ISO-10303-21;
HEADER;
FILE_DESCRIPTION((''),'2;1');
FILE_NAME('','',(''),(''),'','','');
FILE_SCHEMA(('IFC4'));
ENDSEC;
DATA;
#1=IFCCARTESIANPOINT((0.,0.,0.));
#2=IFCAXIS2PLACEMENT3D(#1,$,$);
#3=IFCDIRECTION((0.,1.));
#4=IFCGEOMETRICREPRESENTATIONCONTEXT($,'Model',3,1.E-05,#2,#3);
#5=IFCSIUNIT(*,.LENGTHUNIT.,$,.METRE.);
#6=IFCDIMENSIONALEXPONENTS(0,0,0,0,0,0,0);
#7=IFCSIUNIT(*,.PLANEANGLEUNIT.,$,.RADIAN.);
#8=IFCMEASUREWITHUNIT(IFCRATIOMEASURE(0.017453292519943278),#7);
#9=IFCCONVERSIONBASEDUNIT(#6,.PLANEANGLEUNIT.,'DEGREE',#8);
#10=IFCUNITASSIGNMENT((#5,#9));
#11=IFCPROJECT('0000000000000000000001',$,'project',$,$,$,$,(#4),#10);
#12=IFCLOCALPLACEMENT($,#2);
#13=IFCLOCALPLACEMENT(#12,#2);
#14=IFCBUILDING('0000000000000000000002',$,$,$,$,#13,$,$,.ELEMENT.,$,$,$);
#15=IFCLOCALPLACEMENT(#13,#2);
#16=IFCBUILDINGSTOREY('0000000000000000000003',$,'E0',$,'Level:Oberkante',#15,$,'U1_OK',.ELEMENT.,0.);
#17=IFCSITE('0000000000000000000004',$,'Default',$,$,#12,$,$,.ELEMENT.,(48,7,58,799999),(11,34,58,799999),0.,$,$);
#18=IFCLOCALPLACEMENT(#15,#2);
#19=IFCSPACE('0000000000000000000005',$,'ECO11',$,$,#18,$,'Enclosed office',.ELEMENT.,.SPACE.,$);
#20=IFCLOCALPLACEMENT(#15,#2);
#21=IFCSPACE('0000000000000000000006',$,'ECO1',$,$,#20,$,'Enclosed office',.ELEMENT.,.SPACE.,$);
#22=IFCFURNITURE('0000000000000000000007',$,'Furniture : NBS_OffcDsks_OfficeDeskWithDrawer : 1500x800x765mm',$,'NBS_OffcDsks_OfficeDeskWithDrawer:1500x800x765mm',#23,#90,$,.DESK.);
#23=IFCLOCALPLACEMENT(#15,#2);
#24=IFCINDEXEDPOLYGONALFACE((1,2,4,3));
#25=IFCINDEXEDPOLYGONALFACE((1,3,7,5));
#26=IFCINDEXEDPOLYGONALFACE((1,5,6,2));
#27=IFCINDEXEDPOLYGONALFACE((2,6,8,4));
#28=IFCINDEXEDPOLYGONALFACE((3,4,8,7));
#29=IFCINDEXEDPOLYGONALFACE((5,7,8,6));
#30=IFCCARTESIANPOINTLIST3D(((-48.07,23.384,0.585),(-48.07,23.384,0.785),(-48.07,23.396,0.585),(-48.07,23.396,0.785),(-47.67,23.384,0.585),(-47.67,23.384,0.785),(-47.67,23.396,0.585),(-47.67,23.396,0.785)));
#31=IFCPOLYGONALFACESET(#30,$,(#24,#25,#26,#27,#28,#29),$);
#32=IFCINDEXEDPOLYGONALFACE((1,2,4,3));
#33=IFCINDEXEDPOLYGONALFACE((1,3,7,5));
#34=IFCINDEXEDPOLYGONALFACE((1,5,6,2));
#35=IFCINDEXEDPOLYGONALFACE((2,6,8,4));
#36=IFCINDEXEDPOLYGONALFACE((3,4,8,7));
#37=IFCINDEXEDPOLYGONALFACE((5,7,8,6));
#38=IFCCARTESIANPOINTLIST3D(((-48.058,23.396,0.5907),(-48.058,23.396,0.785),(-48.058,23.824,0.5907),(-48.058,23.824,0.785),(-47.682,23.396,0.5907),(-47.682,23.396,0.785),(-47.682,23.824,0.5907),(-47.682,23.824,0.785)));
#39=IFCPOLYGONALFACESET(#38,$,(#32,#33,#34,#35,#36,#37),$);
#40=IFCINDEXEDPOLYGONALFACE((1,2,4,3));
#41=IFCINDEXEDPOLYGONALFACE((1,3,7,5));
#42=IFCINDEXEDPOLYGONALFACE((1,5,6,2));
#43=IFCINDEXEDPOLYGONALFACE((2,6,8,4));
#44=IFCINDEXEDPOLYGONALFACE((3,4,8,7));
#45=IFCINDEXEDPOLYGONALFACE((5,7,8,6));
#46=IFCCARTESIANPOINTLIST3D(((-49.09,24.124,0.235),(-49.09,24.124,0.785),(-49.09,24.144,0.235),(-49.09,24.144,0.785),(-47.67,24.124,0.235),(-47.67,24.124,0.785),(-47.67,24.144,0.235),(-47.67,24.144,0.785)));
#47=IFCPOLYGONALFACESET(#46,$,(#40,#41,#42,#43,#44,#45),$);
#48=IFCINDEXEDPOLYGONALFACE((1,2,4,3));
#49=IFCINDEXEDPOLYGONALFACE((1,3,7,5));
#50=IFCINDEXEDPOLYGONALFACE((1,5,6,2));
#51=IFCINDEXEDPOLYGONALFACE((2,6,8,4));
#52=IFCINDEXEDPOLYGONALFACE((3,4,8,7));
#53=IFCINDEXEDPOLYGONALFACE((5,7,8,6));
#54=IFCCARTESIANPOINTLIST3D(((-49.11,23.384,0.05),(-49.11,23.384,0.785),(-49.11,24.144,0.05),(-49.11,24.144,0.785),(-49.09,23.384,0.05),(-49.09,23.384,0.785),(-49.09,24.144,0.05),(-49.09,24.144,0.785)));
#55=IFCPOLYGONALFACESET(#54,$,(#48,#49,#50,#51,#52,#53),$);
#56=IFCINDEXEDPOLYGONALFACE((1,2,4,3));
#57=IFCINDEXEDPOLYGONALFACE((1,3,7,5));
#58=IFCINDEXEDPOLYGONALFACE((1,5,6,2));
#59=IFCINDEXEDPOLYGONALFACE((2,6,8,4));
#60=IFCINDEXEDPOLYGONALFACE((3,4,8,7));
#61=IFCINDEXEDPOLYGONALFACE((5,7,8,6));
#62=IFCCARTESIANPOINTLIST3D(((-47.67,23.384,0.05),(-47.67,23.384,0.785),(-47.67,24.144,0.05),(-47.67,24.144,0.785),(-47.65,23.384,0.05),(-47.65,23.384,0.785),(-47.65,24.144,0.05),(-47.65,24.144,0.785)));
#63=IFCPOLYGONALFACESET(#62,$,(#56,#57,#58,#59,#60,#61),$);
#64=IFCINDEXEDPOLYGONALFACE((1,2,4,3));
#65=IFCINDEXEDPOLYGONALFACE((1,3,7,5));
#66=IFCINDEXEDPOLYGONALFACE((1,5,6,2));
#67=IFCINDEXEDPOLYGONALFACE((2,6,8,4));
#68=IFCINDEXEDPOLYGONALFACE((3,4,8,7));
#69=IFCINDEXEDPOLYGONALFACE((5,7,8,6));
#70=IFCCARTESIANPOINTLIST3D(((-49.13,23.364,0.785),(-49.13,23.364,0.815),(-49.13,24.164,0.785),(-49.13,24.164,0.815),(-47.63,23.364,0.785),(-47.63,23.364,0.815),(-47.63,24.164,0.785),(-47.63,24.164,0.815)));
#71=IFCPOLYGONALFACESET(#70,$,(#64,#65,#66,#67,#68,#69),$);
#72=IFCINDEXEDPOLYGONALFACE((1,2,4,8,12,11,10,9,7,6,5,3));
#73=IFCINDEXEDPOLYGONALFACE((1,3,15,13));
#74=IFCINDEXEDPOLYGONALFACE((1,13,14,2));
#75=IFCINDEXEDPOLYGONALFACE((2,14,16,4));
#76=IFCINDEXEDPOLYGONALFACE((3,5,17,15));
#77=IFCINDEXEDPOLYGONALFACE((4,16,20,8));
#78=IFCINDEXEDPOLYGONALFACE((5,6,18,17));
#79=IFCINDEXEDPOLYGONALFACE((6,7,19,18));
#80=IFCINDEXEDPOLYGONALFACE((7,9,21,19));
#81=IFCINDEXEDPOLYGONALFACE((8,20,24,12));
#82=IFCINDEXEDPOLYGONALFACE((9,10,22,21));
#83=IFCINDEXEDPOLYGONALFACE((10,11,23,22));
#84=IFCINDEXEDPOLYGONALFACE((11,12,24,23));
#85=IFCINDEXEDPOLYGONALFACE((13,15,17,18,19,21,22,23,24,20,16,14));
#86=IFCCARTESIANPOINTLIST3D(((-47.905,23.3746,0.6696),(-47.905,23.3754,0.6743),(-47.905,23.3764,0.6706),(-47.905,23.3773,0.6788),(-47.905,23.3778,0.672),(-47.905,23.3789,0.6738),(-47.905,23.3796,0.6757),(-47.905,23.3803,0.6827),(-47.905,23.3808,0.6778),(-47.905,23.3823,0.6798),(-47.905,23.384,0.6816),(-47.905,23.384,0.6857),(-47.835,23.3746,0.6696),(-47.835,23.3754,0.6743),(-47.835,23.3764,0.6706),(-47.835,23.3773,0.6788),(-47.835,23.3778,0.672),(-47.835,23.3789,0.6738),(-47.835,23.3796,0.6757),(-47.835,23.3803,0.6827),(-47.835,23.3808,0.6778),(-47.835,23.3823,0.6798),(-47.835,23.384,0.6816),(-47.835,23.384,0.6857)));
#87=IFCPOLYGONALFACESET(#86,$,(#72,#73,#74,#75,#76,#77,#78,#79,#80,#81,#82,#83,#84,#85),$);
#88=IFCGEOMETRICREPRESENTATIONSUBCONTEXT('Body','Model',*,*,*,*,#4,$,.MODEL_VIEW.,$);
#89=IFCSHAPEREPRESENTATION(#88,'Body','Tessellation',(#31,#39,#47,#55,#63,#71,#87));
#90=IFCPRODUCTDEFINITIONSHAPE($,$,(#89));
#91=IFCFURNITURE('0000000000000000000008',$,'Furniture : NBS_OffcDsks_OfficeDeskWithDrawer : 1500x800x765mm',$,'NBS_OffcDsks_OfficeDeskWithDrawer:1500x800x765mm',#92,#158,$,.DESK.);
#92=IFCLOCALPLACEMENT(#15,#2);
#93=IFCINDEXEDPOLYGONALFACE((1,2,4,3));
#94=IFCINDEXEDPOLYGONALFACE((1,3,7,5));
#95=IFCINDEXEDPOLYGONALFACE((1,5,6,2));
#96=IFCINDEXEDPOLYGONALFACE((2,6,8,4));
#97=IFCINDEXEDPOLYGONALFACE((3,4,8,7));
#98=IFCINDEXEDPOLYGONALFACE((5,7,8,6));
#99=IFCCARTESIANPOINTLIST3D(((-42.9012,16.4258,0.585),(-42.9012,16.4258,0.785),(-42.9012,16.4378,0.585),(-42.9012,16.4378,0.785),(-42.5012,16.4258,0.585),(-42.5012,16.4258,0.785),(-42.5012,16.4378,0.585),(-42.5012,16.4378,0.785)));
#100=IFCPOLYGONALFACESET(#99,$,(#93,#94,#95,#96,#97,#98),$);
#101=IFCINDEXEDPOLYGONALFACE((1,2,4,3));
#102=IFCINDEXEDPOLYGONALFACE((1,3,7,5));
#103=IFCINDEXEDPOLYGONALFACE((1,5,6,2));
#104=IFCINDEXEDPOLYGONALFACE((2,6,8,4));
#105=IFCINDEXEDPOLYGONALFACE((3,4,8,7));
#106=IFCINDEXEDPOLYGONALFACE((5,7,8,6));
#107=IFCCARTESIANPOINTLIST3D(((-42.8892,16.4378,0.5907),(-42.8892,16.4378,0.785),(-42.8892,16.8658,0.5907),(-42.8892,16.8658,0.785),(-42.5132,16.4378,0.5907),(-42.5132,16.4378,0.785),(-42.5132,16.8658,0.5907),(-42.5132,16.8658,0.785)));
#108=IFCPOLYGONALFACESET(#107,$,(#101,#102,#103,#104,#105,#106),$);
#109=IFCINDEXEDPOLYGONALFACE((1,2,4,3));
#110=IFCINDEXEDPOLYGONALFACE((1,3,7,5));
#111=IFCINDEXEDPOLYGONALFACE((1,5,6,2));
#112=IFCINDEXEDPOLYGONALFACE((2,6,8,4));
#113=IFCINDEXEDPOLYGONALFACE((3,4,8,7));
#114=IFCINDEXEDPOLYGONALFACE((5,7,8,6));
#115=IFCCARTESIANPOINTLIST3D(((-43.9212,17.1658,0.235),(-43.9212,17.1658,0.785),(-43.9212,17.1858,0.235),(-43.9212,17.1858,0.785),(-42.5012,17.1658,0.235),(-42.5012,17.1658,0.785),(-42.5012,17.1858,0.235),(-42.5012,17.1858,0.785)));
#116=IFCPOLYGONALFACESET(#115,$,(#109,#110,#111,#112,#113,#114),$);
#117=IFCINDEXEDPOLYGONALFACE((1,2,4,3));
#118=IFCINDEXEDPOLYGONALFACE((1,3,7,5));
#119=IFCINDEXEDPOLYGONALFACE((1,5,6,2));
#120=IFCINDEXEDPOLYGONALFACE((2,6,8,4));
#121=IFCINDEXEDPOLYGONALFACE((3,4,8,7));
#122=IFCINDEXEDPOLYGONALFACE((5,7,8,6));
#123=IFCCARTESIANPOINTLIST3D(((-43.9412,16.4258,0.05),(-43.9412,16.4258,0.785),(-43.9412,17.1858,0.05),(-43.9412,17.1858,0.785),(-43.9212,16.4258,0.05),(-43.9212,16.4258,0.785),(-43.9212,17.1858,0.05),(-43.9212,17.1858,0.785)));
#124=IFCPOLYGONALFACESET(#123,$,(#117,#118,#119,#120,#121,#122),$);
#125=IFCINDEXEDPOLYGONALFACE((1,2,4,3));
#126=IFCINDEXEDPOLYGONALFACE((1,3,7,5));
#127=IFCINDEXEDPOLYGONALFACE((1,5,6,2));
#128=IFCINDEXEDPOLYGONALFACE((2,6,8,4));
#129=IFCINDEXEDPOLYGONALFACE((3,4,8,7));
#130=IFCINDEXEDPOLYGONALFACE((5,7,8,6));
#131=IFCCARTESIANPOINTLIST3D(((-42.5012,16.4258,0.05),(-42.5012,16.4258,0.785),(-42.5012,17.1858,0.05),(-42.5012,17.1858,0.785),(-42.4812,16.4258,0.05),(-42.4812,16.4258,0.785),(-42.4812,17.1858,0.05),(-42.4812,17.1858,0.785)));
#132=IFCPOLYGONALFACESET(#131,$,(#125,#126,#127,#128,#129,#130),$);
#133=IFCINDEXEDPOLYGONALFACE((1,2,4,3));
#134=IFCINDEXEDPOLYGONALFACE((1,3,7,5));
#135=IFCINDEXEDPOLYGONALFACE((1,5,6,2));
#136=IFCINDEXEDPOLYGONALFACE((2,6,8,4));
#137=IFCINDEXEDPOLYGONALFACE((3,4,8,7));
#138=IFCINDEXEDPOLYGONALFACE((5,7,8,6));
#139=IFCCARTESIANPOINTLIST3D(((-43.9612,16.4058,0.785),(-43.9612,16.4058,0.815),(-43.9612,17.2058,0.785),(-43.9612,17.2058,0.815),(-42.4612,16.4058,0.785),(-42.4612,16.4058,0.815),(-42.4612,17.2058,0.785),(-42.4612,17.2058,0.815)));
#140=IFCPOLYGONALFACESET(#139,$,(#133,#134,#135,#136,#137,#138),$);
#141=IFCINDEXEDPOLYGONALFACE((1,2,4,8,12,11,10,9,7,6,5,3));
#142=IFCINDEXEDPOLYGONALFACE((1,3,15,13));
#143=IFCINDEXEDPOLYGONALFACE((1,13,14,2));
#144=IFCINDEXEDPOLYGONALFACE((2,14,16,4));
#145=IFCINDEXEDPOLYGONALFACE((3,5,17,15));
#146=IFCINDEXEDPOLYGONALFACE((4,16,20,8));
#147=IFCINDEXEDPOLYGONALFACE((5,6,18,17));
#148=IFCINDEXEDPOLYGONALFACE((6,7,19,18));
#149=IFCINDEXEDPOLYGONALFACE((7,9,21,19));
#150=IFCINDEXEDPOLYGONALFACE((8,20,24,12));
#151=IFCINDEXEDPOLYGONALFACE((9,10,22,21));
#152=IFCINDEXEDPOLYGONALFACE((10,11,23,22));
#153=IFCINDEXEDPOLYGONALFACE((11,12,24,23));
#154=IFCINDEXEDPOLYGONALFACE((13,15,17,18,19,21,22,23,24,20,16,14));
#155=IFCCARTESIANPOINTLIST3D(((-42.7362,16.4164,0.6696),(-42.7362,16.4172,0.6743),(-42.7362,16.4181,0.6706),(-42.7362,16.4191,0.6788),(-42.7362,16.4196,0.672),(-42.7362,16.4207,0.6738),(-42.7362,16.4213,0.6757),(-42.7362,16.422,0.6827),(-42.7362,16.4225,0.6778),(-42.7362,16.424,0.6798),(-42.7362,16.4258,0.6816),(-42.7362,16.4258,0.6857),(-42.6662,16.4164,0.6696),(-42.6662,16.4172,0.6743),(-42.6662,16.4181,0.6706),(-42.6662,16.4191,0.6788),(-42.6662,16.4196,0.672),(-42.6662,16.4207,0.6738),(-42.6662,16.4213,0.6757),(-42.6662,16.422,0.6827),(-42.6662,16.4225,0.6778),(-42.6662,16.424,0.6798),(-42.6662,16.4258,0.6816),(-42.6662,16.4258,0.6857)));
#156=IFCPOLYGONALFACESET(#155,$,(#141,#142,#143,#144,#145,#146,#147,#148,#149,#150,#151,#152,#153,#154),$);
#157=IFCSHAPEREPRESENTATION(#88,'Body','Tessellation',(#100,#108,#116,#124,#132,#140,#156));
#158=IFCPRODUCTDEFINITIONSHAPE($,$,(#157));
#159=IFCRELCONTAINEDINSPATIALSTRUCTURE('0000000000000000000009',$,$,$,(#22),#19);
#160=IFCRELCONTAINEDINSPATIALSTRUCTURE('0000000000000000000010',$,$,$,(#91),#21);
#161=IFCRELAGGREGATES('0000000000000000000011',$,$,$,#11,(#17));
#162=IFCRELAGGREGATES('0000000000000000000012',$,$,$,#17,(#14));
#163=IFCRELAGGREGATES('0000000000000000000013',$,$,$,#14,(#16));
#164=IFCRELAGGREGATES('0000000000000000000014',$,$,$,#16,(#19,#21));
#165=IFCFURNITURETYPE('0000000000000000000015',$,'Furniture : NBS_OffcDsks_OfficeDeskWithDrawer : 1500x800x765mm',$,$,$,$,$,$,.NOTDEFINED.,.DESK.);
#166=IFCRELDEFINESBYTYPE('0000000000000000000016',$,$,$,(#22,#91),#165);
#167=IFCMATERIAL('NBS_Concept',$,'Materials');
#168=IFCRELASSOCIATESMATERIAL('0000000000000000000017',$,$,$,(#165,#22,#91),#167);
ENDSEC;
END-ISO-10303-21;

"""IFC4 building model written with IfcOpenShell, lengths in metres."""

from ifc_helpers import new_model, entity, si_unit, converted_unit, direction, frame, origin, place, context, subcontext, project, spatial, line, arc, indexed_curve, outline, extrude, source, transform, mapped, material, type_object, type_shapes, element, save


model = new_model("IFC4")

# Units and contexts
model_context = context("Model", 3, precision=1e-05, world=origin(), true_north=direction((0.0, 1.0)))
body_context = subcontext(model_context, "Body", "Model", "MODEL_VIEW")
ifc_project = project(units=[si_unit("LENGTHUNIT", "METRE"), converted_unit("PLANEANGLEUNIT", "DEGREE", entity("IfcRatioMeasure", 0.017453292519943278), si_unit("PLANEANGLEUNIT", "RADIAN"), dimensions=[0, 0, 0, 0, 0, 0, 0])], contexts=[model_context])

# Site, building, storey
site_placement = place(None, origin())
site = spatial("IfcSite", under=ifc_project, at=site_placement, Name="Default", CompositionType="ELEMENT", RefLatitude=(48, 7, 58, 799999), RefLongitude=(11, 34, 58, 799999), RefElevation=0.0)
building_placement = place(site_placement, origin())
building = spatial("IfcBuilding", under=site, at=building_placement, CompositionType="ELEMENT")
storey_placement = place(building_placement, origin())
storey = spatial("IfcBuildingStorey", under=building, at=storey_placement, Name="E0", ObjectType="Level:Oberkante", LongName="U1_OK", CompositionType="ELEMENT", Elevation=0.0)

# Shared definitions
ifc_material_1 = material(Name="NBS_Concept", Category="Materials")
furniture_type = type_object("IfcFurnitureType", Name="Furniture : NBS_OffcDsks_OfficeDeskWithDrawer : 1500x800x765mm", AssemblyPlace="NOTDEFINED", PredefinedType="DESK", material=ifc_material_1)
shared_shape = source(origin(), body_context, "Body", "SweptSolid", [
    extrude(outline(indexed_curve([(-0.006, -0.2), (0.006, -0.2), (0.006, 0.2), (-0.006, 0.2), (-0.006, -0.2)], self_intersect=False)), frame((0.51, -0.374, 0.535), z_axis=(0.0, 0.0, 1.0), x_axis=(0.0, 1.0, 0.0)), (0.0, 0.0, 1.0), 0.2),
    extrude(outline(indexed_curve([(-0.188, -0.214), (0.188, -0.214), (0.188, 0.214), (-0.188, 0.214), (-0.188, -0.214)], self_intersect=False)), frame((0.51, -0.154, 0.5407), z_axis=(0.0, 0.0, 1.0), x_axis=(-1.0, 0.0, 0.0)), (0.0, 0.0, 1.0), 0.1943),
    extrude(outline(indexed_curve([(-0.71, -0.01), (0.71, -0.01), (0.71, 0.01), (-0.71, 0.01), (-0.71, -0.01)], self_intersect=False)), frame((0.0, 0.37, 0.185), z_axis=(0.0, 0.0, 1.0), x_axis=(-1.0, 0.0, 0.0)), (0.0, 0.0, 1.0), 0.55),
    extrude(outline(indexed_curve([(-0.01, -0.38), (0.01, -0.38), (0.01, 0.38), (-0.01, 0.38), (-0.01, -0.38)], self_intersect=False)), frame((-0.72, 0.0, 0.0), z_axis=(0.0, 0.0, 1.0), x_axis=(-1.0, 0.0, 0.0)), (0.0, 0.0, 1.0), 0.735),
    extrude(outline(indexed_curve([(-0.01, -0.38), (0.01, -0.38), (0.01, 0.38), (-0.01, 0.38), (-0.01, -0.38)], self_intersect=False)), frame((0.72, 0.0, 0.0), z_axis=(0.0, 0.0, 1.0), x_axis=(-1.0, 0.0, 0.0)), (0.0, 0.0, 1.0), 0.735),
    extrude(outline(indexed_curve([(-0.75, -0.4), (0.75, -0.4), (0.75, 0.4), (-0.75, 0.4), (-0.75, -0.4)], self_intersect=False)), frame((0.0, 0.0, 0.735), z_axis=(0.0, 0.0, 1.0), x_axis=(-1.0, 0.0, 0.0)), (0.0, 0.0, 1.0), 0.03),
    extrude(outline(indexed_curve([(0.0086, -0.0059), (0.0061, -0.0027), (0.0025, -0.001), (-0.0007, 0.0009), (-0.0034, 0.0035), (-0.0076, 0.0035), (-0.0007, -0.0032)], segments=[arc(1, 2, 3), arc(3, 4, 5), line(5, 6), arc(6, 7, 1)], self_intersect=False)), frame((0.475, -0.3835, 0.6281), z_axis=(1.0, 0.0, 0.0), x_axis=(0.0, 0.0, -1.0)), (0.0, 0.0, 1.0), 0.07),
])
type_shapes(furniture_type, [shared_shape])

# Shared definitions
space_1_placement = place(storey_placement, origin())
space_1 = spatial("IfcSpace", under=storey, at=space_1_placement, Name="ECO11", LongName="Enclosed office", CompositionType="ELEMENT", PredefinedType="SPACE")

# Furniture
furniture_1_placement = place(space_1_placement, frame((-48.38, 23.764, 0.05)))
element("IfcFurniture", 1, at=furniture_1_placement, inside=space_1, type_object=furniture_type, material=ifc_material_1, Name="Furniture : NBS_OffcDsks_OfficeDeskWithDrawer : 1500x800x765mm", ObjectType="NBS_OffcDsks_OfficeDeskWithDrawer:1500x800x765mm", PredefinedType="DESK", context=body_context, shape_type="MappedRepresentation", body=[
    mapped(shared_shape, transform((0.0, 0.0, 0.0), scale=1.0)),
])

# Shared definitions
space_2_placement = place(storey_placement, origin())
space_2 = spatial("IfcSpace", under=storey, at=space_2_placement, Name="ECO1", LongName="Enclosed office", CompositionType="ELEMENT", PredefinedType="SPACE")

# Furniture
furniture_2_placement = place(space_2_placement, frame((-43.2112, 16.8058, 0.05)))
element("IfcFurniture", 2, at=furniture_2_placement, inside=space_2, type_object=furniture_type, material=ifc_material_1, Name="Furniture : NBS_OffcDsks_OfficeDeskWithDrawer : 1500x800x765mm", ObjectType="NBS_OffcDsks_OfficeDeskWithDrawer:1500x800x765mm", PredefinedType="DESK", context=body_context, shape_type="MappedRepresentation", body=[
    mapped(shared_shape, transform((0.0, 0.0, 0.0), scale=1.0)),
])

save(model, "model.ifc")
